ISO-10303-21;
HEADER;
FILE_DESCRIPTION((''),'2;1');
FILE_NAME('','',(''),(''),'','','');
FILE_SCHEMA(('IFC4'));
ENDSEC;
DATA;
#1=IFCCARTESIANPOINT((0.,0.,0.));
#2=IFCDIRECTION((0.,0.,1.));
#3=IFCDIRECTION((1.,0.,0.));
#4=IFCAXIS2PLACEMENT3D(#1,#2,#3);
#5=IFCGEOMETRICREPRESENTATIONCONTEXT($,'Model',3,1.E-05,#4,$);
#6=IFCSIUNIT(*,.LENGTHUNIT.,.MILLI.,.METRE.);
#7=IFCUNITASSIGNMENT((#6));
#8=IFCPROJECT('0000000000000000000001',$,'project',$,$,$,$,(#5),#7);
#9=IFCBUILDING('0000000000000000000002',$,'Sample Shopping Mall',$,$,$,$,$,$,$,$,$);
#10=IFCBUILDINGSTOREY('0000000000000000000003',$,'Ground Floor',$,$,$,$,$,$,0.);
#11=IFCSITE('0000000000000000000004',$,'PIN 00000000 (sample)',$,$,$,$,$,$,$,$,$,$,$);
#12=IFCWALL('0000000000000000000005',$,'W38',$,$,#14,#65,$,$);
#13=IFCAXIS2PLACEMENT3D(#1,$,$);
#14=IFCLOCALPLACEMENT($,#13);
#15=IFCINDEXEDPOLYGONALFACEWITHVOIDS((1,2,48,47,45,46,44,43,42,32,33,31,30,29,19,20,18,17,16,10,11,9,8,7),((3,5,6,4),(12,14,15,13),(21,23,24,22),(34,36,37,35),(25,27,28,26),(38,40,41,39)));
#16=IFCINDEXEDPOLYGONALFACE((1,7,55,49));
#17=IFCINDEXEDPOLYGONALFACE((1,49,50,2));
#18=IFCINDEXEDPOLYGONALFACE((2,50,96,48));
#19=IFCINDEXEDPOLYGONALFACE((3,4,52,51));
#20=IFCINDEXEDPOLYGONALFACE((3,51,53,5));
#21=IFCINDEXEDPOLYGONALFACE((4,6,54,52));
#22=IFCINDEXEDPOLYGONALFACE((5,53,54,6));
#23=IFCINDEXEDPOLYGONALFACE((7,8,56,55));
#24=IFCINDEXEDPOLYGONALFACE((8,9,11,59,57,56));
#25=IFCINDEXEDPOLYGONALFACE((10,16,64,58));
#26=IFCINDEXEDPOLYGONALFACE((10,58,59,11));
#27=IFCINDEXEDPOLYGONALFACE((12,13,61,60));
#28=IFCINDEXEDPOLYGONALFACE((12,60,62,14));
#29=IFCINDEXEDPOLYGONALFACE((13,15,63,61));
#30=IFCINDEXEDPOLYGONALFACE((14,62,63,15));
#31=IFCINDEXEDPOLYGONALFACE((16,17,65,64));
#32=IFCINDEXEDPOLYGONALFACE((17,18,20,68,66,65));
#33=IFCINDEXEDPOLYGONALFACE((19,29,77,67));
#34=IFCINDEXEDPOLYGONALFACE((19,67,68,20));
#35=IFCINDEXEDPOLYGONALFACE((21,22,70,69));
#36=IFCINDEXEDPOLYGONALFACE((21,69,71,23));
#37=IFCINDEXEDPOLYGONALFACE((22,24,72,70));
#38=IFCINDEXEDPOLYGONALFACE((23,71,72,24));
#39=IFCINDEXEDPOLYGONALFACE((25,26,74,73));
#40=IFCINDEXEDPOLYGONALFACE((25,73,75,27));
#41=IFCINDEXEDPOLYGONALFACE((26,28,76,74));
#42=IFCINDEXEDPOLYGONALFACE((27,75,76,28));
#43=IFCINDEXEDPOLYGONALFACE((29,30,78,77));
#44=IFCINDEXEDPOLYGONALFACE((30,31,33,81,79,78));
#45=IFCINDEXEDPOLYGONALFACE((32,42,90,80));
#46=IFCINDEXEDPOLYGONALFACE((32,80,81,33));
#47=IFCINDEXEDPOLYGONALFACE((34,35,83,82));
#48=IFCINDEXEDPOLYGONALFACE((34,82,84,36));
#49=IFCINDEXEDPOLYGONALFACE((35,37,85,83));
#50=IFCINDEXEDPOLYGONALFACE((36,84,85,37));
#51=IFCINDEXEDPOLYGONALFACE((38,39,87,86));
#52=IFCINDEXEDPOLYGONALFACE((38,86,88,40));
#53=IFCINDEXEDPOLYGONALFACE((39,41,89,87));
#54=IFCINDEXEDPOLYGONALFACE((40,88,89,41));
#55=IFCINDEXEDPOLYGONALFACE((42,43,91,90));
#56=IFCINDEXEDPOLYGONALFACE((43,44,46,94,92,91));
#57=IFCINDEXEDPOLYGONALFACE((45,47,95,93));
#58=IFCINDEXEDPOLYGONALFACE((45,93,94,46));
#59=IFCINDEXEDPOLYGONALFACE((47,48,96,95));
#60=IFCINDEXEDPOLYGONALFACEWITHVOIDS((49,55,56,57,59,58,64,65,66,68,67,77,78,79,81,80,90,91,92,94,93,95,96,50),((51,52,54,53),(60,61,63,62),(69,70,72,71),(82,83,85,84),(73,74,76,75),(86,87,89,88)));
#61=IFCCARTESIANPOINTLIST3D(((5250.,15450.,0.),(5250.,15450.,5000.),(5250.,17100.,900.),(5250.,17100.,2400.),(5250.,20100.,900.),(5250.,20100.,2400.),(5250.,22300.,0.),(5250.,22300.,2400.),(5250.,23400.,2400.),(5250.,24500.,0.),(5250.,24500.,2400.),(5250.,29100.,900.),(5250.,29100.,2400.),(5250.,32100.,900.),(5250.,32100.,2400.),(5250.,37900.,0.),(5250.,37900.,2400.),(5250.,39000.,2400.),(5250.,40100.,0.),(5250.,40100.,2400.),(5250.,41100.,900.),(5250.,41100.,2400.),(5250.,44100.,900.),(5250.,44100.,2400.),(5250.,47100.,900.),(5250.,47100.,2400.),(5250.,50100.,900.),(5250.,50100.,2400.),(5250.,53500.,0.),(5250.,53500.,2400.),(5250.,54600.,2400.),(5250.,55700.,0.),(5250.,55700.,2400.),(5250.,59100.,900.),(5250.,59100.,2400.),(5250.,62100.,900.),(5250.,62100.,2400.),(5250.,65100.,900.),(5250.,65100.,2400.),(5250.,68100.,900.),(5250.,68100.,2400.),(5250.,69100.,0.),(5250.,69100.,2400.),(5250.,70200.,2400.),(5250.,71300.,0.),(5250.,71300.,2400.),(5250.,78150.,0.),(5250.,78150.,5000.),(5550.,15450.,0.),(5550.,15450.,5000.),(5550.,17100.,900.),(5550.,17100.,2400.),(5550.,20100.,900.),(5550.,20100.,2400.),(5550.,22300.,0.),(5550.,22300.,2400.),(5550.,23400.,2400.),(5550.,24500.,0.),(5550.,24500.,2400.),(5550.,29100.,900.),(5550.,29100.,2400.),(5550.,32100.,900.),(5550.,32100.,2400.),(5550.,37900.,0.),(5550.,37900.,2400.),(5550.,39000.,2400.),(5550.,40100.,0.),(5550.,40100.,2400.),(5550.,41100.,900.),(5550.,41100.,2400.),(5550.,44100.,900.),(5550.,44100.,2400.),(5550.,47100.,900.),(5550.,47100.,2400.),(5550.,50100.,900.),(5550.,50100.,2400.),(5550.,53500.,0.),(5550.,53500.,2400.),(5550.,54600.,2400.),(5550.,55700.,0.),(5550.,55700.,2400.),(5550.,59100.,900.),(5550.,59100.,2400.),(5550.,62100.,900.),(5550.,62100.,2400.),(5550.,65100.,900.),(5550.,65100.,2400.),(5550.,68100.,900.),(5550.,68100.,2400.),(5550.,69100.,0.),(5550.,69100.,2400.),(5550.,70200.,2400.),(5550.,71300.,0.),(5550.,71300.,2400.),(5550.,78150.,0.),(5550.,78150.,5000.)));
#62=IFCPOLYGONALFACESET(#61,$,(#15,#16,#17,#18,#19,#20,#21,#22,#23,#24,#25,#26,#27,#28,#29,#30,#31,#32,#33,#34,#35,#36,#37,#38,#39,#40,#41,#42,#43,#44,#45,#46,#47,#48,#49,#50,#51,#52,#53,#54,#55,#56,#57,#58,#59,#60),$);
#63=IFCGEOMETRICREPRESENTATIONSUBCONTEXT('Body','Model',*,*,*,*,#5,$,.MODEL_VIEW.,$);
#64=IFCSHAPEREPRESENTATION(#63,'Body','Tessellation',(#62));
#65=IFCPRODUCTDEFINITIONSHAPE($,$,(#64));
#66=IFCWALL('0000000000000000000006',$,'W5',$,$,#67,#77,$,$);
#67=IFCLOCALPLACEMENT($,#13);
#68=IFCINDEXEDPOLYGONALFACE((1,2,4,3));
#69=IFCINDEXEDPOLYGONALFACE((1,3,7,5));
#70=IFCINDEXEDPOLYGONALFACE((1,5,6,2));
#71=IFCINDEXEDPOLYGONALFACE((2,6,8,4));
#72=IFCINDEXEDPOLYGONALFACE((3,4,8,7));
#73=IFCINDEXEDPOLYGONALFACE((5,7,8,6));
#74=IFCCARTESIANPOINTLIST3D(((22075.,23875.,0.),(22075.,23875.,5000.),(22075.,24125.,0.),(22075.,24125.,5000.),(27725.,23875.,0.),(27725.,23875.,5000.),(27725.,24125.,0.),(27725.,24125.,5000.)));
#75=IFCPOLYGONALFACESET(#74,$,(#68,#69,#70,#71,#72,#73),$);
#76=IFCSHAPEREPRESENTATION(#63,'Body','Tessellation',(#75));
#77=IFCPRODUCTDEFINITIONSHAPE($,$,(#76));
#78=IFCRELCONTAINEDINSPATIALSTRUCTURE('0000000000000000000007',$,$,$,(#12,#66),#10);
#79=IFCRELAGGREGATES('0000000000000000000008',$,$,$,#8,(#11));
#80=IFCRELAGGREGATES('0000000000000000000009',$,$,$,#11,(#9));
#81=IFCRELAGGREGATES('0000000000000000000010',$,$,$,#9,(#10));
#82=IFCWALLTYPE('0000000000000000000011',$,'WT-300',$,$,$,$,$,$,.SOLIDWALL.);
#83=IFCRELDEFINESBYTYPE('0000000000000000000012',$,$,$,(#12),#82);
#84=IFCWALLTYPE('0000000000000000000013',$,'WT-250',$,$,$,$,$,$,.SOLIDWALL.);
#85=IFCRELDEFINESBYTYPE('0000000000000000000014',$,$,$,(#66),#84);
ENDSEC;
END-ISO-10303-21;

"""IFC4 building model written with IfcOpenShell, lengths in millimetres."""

from ifc_helpers import new_model, si_unit, frame, origin_with_axes, place, context, subcontext, project, spatial, indexed_curve, outline, extrude, type_object, element, save


model = new_model("IFC4")

# Units and contexts
model_context = context("Model", 3, precision=1e-05, world=origin_with_axes())
body_context = subcontext(model_context, "Body", "Model", "MODEL_VIEW")
ifc_project = project(units=[si_unit("LENGTHUNIT", "METRE", prefix="MILLI")], contexts=[model_context])

# Site, building, storey
site = spatial("IfcSite", under=ifc_project, Name="PIN 00000000 (sample)")
building = spatial("IfcBuilding", under=site, Name="Sample Shopping Mall")
storey = spatial("IfcBuildingStorey", under=building, Name="Ground Floor", Elevation=0.0)

# Wall, openings
wall_type_1 = type_object("IfcWallType", Name="WT-300", PredefinedType="SOLIDWALL")
wall_1_placement = place(None, frame((5550.0, 15450.0, 0.0), z_axis=(0.0, 0.0, 1.0), x_axis=(0.0, 1.0, 0.0)))
wall_1 = element("IfcWall", 1, at=wall_1_placement, inside=storey, type_object=wall_type_1, Name="W38", context=body_context, shape_type="SweptSolid", body=[
    extrude(outline(indexed_curve([(0.0, 0.0), (0.0, 300.0), (62700.0, 300.0), (62700.0, 0.0), (0.0, 0.0)], self_intersect=False)), origin_with_axes(), (0.0, 0.0, 1.0), 5000.0),
])
opening_1_placement = place(wall_1_placement, frame((6850.0, -100.0, 0.0), z_axis=(0.0, 0.0, 1.0), x_axis=(1.0, 0.0, 0.0)))
element("IfcOpeningElement", 2, at=opening_1_placement, cuts=wall_1, context=body_context, shape_type="SweptSolid", body=[
    extrude(outline(indexed_curve([(0.0, 0.0), (0.0, 500.0), (1100.0, 500.0), (1100.0, 0.0), (0.0, 0.0)], self_intersect=False)), origin_with_axes(), (0.0, 0.0, 1.0), 2400.0),
])
opening_2_placement = place(wall_1_placement, frame((7950.0, -100.0, 0.0), z_axis=(0.0, 0.0, 1.0), x_axis=(1.0, 0.0, 0.0)))
element("IfcOpeningElement", 3, at=opening_2_placement, cuts=wall_1, context=body_context, shape_type="SweptSolid", body=[
    extrude(outline(indexed_curve([(0.0, 0.0), (0.0, 500.0), (1100.0, 500.0), (1100.0, 0.0), (0.0, 0.0)], self_intersect=False)), origin_with_axes(), (0.0, 0.0, 1.0), 2400.0),
])
opening_3_placement = place(wall_1_placement, frame((22450.0, -100.0, 0.0), z_axis=(0.0, 0.0, 1.0), x_axis=(1.0, 0.0, 0.0)))
element("IfcOpeningElement", 4, at=opening_3_placement, cuts=wall_1, context=body_context, shape_type="SweptSolid", body=[
    extrude(outline(indexed_curve([(0.0, 0.0), (0.0, 500.0), (1100.0, 500.0), (1100.0, 0.0), (0.0, 0.0)], self_intersect=False)), origin_with_axes(), (0.0, 0.0, 1.0), 2400.0),
])
opening_4_placement = place(wall_1_placement, frame((23550.0, -100.0, 0.0), z_axis=(0.0, 0.0, 1.0), x_axis=(1.0, 0.0, 0.0)))
element("IfcOpeningElement", 5, at=opening_4_placement, cuts=wall_1, context=body_context, shape_type="SweptSolid", body=[
    extrude(outline(indexed_curve([(0.0, 0.0), (0.0, 500.0), (1100.0, 500.0), (1100.0, 0.0), (0.0, 0.0)], self_intersect=False)), origin_with_axes(), (0.0, 0.0, 1.0), 2400.0),
])
opening_5_placement = place(wall_1_placement, frame((38050.0, -100.0, 0.0), z_axis=(0.0, 0.0, 1.0), x_axis=(1.0, 0.0, 0.0)))
element("IfcOpeningElement", 6, at=opening_5_placement, cuts=wall_1, context=body_context, shape_type="SweptSolid", body=[
    extrude(outline(indexed_curve([(0.0, 0.0), (0.0, 500.0), (1100.0, 500.0), (1100.0, 0.0), (0.0, 0.0)], self_intersect=False)), origin_with_axes(), (0.0, 0.0, 1.0), 2400.0),
])
opening_6_placement = place(wall_1_placement, frame((39150.0, -100.0, 0.0), z_axis=(0.0, 0.0, 1.0), x_axis=(1.0, 0.0, 0.0)))
element("IfcOpeningElement", 7, at=opening_6_placement, cuts=wall_1, context=body_context, shape_type="SweptSolid", body=[
    extrude(outline(indexed_curve([(0.0, 0.0), (0.0, 500.0), (1100.0, 500.0), (1100.0, 0.0), (0.0, 0.0)], self_intersect=False)), origin_with_axes(), (0.0, 0.0, 1.0), 2400.0),
])
opening_7_placement = place(wall_1_placement, frame((53650.0, -100.0, 0.0), z_axis=(0.0, 0.0, 1.0), x_axis=(1.0, 0.0, 0.0)))
element("IfcOpeningElement", 8, at=opening_7_placement, cuts=wall_1, context=body_context, shape_type="SweptSolid", body=[
    extrude(outline(indexed_curve([(0.0, 0.0), (0.0, 500.0), (1100.0, 500.0), (1100.0, 0.0), (0.0, 0.0)], self_intersect=False)), origin_with_axes(), (0.0, 0.0, 1.0), 2400.0),
])
opening_8_placement = place(wall_1_placement, frame((54750.0, -100.0, 0.0), z_axis=(0.0, 0.0, 1.0), x_axis=(1.0, 0.0, 0.0)))
element("IfcOpeningElement", 9, at=opening_8_placement, cuts=wall_1, context=body_context, shape_type="SweptSolid", body=[
    extrude(outline(indexed_curve([(0.0, 0.0), (0.0, 500.0), (1100.0, 500.0), (1100.0, 0.0), (0.0, 0.0)], self_intersect=False)), origin_with_axes(), (0.0, 0.0, 1.0), 2400.0),
])
opening_9_placement = place(wall_1_placement, frame((1650.0, -100.0, 900.0), z_axis=(0.0, 0.0, 1.0), x_axis=(1.0, 0.0, 0.0)))
element("IfcOpeningElement", 10, at=opening_9_placement, cuts=wall_1, context=body_context, shape_type="SweptSolid", body=[
    extrude(outline(indexed_curve([(0.0, 0.0), (0.0, 500.0), (3000.0, 500.0), (3000.0, 0.0), (0.0, 0.0)], self_intersect=False)), origin_with_axes(), (0.0, 0.0, 1.0), 1500.0),
])
opening_10_placement = place(wall_1_placement, frame((13650.0, -100.0, 900.0), z_axis=(0.0, 0.0, 1.0), x_axis=(1.0, 0.0, 0.0)))
element("IfcOpeningElement", 11, at=opening_10_placement, cuts=wall_1, context=body_context, shape_type="SweptSolid", body=[
    extrude(outline(indexed_curve([(0.0, 0.0), (0.0, 500.0), (3000.0, 500.0), (3000.0, 0.0), (0.0, 0.0)], self_intersect=False)), origin_with_axes(), (0.0, 0.0, 1.0), 1500.0),
])
opening_11_placement = place(wall_1_placement, frame((25650.0, -100.0, 900.0), z_axis=(0.0, 0.0, 1.0), x_axis=(1.0, 0.0, 0.0)))
element("IfcOpeningElement", 12, at=opening_11_placement, cuts=wall_1, context=body_context, shape_type="SweptSolid", body=[
    extrude(outline(indexed_curve([(0.0, 0.0), (0.0, 500.0), (3000.0, 500.0), (3000.0, 0.0), (0.0, 0.0)], self_intersect=False)), origin_with_axes(), (0.0, 0.0, 1.0), 1500.0),
])
opening_12_placement = place(wall_1_placement, frame((31650.0, -100.0, 900.0), z_axis=(0.0, 0.0, 1.0), x_axis=(1.0, 0.0, 0.0)))
element("IfcOpeningElement", 13, at=opening_12_placement, cuts=wall_1, context=body_context, shape_type="SweptSolid", body=[
    extrude(outline(indexed_curve([(0.0, 0.0), (0.0, 500.0), (3000.0, 500.0), (3000.0, 0.0), (0.0, 0.0)], self_intersect=False)), origin_with_axes(), (0.0, 0.0, 1.0), 1500.0),
])
opening_13_placement = place(wall_1_placement, frame((43650.0, -100.0, 900.0), z_axis=(0.0, 0.0, 1.0), x_axis=(1.0, 0.0, 0.0)))
element("IfcOpeningElement", 14, at=opening_13_placement, cuts=wall_1, context=body_context, shape_type="SweptSolid", body=[
    extrude(outline(indexed_curve([(0.0, 0.0), (0.0, 500.0), (3000.0, 500.0), (3000.0, 0.0), (0.0, 0.0)], self_intersect=False)), origin_with_axes(), (0.0, 0.0, 1.0), 1500.0),
])
opening_14_placement = place(wall_1_placement, frame((49650.0, -100.0, 900.0), z_axis=(0.0, 0.0, 1.0), x_axis=(1.0, 0.0, 0.0)))
element("IfcOpeningElement", 15, at=opening_14_placement, cuts=wall_1, context=body_context, shape_type="SweptSolid", body=[
    extrude(outline(indexed_curve([(0.0, 0.0), (0.0, 500.0), (3000.0, 500.0), (3000.0, 0.0), (0.0, 0.0)], self_intersect=False)), origin_with_axes(), (0.0, 0.0, 1.0), 1500.0),
])

# Wall
wall_type_2 = type_object("IfcWallType", Name="WT-250", PredefinedType="SOLIDWALL")
wall_2_placement = place(None, frame((22075.0, 23875.0, 0.0), z_axis=(0.0, 0.0, 1.0), x_axis=(1.0, 0.0, 0.0)))
element("IfcWall", 16, at=wall_2_placement, inside=storey, type_object=wall_type_2, Name="W5", context=body_context, shape_type="SweptSolid", body=[
    extrude(outline(indexed_curve([(0.0, 0.0), (0.0, 250.0), (5650.0, 250.0), (5650.0, 0.0), (0.0, 0.0)], self_intersect=False)), origin_with_axes(), (0.0, 0.0, 1.0), 5000.0),
])

save(model, "model.ifc")
